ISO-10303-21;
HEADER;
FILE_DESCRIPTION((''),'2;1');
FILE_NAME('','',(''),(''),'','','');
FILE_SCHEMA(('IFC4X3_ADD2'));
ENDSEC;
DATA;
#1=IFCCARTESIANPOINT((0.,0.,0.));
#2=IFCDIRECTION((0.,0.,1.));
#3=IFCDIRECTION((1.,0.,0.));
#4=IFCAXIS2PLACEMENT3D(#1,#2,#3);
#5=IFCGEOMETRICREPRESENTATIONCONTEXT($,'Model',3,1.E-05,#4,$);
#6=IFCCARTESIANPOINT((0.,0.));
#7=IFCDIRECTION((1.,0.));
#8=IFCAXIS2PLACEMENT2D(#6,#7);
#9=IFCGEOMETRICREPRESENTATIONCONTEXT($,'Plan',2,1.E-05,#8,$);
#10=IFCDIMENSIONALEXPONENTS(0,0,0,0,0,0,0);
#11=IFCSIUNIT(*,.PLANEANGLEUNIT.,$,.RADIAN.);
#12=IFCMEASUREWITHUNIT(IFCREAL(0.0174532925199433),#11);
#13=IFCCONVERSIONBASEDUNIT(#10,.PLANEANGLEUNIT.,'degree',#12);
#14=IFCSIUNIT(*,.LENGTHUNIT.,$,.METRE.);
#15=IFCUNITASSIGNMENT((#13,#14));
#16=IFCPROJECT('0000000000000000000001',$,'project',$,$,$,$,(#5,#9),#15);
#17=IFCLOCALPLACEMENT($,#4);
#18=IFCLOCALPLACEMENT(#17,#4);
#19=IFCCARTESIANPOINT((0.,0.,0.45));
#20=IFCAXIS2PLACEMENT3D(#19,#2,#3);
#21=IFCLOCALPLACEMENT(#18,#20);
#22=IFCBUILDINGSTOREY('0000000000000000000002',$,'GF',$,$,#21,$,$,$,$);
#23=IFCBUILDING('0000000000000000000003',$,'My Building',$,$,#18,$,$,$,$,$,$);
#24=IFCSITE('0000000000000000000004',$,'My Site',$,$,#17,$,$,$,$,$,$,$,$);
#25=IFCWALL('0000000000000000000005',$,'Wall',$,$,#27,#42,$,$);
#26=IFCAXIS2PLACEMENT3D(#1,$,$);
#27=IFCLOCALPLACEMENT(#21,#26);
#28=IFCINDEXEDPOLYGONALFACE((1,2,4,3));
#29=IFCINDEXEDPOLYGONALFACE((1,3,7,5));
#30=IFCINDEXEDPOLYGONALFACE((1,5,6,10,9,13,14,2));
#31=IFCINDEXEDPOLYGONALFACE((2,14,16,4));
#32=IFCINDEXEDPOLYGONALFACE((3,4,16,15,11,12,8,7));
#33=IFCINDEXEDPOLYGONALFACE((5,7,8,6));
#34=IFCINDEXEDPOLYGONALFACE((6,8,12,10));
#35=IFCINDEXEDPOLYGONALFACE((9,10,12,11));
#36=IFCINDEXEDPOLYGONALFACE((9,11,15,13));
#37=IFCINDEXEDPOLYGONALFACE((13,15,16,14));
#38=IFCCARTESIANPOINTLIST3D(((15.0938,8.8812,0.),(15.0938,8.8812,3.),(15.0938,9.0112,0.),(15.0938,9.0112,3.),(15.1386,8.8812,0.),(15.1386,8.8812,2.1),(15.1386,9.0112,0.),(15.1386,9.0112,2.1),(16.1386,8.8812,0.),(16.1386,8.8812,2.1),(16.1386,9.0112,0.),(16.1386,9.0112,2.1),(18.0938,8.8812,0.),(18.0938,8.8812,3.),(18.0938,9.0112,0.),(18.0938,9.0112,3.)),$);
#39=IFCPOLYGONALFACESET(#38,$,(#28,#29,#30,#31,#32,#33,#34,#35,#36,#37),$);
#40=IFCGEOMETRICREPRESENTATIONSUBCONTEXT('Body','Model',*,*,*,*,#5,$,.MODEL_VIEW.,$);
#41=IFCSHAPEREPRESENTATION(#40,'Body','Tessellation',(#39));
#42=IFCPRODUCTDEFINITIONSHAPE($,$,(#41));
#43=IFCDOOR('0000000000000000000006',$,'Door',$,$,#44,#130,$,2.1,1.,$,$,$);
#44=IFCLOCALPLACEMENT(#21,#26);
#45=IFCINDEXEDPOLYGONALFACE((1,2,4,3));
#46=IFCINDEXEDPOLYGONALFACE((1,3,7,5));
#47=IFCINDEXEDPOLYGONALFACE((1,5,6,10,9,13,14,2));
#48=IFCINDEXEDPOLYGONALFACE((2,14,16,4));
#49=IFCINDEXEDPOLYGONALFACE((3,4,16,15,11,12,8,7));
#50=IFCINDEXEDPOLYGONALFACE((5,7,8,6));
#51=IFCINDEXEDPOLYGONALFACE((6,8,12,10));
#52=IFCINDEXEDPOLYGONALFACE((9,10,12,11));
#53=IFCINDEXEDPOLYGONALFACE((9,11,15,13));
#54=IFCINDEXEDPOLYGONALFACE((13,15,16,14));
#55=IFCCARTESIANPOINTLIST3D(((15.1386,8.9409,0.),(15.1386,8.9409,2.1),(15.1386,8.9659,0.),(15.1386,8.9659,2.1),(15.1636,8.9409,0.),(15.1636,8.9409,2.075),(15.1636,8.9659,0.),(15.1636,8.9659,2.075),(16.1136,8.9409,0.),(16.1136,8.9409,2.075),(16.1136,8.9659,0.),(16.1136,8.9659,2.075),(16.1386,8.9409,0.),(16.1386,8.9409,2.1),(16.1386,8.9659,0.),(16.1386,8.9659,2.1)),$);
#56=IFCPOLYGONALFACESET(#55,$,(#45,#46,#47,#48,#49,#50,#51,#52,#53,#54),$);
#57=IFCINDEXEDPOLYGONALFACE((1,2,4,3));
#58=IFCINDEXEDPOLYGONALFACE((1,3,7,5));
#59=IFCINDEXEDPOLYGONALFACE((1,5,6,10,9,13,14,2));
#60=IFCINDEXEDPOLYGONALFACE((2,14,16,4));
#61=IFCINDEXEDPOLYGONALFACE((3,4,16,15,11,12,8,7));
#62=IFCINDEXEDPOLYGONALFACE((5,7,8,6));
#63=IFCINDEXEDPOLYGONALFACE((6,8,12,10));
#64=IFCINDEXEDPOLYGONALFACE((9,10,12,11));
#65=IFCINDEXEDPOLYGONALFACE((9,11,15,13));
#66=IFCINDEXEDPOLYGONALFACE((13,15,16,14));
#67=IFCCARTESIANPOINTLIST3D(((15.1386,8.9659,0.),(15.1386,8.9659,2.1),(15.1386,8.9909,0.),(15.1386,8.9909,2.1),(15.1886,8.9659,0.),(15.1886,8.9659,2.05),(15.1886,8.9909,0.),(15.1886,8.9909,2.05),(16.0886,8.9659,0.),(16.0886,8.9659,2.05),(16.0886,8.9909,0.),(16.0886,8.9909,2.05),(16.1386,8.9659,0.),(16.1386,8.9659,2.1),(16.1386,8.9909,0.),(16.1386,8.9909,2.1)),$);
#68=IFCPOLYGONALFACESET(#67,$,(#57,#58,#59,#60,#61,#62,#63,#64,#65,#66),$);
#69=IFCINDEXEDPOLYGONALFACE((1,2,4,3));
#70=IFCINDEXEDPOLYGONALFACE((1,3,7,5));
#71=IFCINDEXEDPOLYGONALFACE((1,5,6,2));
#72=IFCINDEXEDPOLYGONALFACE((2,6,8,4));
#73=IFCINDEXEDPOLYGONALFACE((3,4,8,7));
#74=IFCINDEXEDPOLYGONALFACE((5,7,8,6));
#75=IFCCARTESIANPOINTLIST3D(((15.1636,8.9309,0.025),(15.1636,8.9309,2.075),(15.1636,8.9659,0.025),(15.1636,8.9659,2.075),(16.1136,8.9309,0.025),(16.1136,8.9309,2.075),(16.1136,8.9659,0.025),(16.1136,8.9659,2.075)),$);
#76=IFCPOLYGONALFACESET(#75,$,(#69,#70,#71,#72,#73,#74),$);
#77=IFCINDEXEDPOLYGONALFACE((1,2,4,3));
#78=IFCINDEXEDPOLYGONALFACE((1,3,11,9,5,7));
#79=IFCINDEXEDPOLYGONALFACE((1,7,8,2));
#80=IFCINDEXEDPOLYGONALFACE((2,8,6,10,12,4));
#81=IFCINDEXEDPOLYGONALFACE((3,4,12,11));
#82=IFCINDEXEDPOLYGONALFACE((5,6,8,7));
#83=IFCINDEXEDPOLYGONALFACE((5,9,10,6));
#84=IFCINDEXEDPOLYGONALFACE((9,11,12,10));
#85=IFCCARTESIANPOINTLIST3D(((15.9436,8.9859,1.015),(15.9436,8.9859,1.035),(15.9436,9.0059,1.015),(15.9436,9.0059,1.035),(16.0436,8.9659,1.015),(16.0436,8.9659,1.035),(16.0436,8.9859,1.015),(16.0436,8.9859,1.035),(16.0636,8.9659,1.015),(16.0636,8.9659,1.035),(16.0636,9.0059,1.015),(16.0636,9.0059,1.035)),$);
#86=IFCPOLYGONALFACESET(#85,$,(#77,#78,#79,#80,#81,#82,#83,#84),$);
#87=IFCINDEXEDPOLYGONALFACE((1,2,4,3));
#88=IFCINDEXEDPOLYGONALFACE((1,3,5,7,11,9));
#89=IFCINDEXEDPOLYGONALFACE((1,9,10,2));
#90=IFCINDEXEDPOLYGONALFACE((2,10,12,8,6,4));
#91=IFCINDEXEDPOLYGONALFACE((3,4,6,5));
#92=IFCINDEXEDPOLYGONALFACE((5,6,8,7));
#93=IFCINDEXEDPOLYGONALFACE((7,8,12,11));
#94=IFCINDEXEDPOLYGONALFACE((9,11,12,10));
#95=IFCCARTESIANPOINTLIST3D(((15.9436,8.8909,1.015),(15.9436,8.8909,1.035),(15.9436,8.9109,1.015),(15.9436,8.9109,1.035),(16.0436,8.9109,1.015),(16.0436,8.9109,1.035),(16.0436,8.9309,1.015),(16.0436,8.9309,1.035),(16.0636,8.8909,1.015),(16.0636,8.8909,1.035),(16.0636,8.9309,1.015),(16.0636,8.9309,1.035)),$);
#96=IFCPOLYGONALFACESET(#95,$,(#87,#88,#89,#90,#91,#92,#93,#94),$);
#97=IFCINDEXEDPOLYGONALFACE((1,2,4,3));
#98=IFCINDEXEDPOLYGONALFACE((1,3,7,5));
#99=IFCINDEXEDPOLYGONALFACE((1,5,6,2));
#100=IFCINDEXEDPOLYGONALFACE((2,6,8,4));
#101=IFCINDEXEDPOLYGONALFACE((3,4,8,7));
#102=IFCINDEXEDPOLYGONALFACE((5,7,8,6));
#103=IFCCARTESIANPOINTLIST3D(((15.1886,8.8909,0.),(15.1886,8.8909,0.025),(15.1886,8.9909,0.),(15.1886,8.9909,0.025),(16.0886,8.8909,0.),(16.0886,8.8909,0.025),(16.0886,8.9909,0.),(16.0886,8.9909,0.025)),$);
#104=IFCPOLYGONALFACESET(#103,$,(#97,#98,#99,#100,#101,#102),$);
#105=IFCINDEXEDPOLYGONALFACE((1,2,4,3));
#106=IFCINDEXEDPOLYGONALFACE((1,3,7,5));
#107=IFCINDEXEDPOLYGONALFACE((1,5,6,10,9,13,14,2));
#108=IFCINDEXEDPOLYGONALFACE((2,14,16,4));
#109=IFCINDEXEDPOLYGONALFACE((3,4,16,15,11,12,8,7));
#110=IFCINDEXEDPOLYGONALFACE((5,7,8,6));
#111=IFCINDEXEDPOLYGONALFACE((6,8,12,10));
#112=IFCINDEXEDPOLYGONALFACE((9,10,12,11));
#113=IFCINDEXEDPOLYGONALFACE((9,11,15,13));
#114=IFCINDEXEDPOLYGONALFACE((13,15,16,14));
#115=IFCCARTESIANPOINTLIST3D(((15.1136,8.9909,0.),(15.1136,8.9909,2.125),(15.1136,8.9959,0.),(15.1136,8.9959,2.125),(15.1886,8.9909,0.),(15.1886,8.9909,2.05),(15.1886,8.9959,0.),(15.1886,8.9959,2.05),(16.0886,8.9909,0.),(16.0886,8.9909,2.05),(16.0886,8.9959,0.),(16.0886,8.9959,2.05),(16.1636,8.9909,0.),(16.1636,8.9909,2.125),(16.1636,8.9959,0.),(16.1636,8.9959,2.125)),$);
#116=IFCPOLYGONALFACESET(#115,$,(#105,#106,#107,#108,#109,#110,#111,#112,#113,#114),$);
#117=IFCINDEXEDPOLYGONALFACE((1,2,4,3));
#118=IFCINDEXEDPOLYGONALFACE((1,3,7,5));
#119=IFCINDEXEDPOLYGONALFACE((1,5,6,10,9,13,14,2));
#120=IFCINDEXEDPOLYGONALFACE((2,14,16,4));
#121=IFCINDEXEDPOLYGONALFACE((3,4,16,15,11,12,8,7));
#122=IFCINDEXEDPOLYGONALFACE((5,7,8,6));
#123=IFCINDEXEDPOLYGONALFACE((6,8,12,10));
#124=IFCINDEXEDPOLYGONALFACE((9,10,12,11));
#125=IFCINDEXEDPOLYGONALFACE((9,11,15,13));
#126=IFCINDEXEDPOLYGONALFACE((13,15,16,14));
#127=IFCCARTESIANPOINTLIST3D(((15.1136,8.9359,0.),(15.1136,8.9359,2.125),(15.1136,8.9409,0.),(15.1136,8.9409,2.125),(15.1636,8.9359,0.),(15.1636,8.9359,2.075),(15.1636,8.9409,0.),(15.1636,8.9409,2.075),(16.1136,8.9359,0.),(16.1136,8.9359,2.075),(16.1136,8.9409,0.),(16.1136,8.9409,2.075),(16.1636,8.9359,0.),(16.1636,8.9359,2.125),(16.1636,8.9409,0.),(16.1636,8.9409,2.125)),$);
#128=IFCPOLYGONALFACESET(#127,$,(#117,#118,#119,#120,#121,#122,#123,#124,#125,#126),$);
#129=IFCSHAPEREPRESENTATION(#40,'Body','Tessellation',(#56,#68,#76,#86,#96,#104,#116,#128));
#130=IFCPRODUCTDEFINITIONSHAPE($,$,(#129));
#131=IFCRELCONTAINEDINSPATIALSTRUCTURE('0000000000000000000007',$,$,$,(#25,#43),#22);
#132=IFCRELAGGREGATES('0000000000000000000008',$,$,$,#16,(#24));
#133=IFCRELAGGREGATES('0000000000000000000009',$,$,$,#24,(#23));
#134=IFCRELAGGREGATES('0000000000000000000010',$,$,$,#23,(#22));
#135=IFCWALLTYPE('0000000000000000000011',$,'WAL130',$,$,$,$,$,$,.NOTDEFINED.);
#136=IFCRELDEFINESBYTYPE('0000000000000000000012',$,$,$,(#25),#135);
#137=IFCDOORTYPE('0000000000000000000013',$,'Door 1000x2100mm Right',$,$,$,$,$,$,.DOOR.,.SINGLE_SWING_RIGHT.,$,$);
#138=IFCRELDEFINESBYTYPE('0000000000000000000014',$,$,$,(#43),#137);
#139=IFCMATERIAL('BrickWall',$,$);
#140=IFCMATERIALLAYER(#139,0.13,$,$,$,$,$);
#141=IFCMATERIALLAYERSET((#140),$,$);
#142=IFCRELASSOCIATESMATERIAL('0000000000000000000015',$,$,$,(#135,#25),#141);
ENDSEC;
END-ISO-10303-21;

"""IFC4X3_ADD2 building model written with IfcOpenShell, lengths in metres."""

from ifc_helpers import new_model, entity, si_unit, converted_unit, frame, origin_with_axes, origin_2d_with_axis, place, context, subcontext, project, spatial, line, indexed_curve, outline, extrude, shape, source, transform, mapped, material, layer, layer_set, layer_usage, type_object, type_shapes, element, fill, save


model = new_model("IFC4X3_ADD2")

# Units and contexts
model_context = context("Model", 3, precision=1e-05, world=origin_with_axes())
plan_context = context("Plan", 2, precision=1e-05, world=origin_2d_with_axis())
body_context_1 = subcontext(model_context, "Body", "Model", "MODEL_VIEW")
body_context_2 = subcontext(plan_context, "Body", "Plan", "PLAN_VIEW")
ifc_project = project(units=[converted_unit("PLANEANGLEUNIT", "degree", entity("IfcReal", 0.0174532925199433), si_unit("PLANEANGLEUNIT", "RADIAN"), dimensions=[0, 0, 0, 0, 0, 0, 0]), si_unit("LENGTHUNIT", "METRE")], contexts=[model_context, plan_context])

# Site, building, storey
site_placement = place(None, origin_with_axes())
site = spatial("IfcSite", under=ifc_project, at=site_placement, Name="My Site")
building_placement = place(site_placement, origin_with_axes())
building = spatial("IfcBuilding", under=site, at=building_placement, Name="My Building")
storey_placement = place(building_placement, frame((0.0, 0.0, 0.45), z_axis=(0.0, 0.0, 1.0), x_axis=(1.0, 0.0, 0.0)))
storey = spatial("IfcBuildingStorey", under=building, at=storey_placement, Name="GF")

# Shared definitions
ifc_material_1 = material(Name="BrickWall")

# Wall, opening, door
ifc_layer_1 = layer(ifc_material_1, 0.13)
ifc_layer_set_1 = layer_set([ifc_layer_1])
ifc_layer_usage_1 = layer_usage(ifc_layer_set_1, "AXIS2", "POSITIVE", 0.0)
wall_type_1 = type_object("IfcWallType", Name="WAL130", PredefinedType="NOTDEFINED", material=ifc_layer_set_1)
wall_1_placement = place(storey_placement, frame((15.0938, 8.8812, 0.0), z_axis=(0.0, 0.0, 1.0), x_axis=(1.0, 0.0, 0.0)))
wall_1 = element("IfcWall", 1, at=wall_1_placement, inside=storey, type_object=wall_type_1, material=ifc_layer_usage_1, Name="Wall", context=body_context_1, shape_type="SweptSolid", body=[
    extrude(outline(indexed_curve([(0.0, 0.0), (0.0, 0.13), (3.0, 0.13), (3.0, 0.0), (0.0, 0.0)], self_intersect=False)), origin_with_axes(), (0.0, 0.0, 1.0), 3.0),
])
shared_shape_1 = source(origin_with_axes(), body_context_1, "Body", "SweptSolid", [
    extrude(outline(indexed_curve([(0.0, 0.0), (1.0, 0.0), (1.0, 2.1), (0.0, 2.1)], segments=[line(1, 2, 3, 4, 1)])), frame((0.0, -0.6, 0.0), z_axis=(0.0, -1.0, 0.0), x_axis=(1.0, 0.0, 0.0)), (0.0, 0.0, -1.0), 1.2),
])
opening_1_placement = place(wall_1_placement, frame((1.0447, 0.1097, 0.0), z_axis=(0.0, 0.0, 1.0), x_axis=(-1.0, 0.0, 0.0)))
opening_1 = element("IfcOpeningElement", 2, at=opening_1_placement, cuts=wall_1, PredefinedType="OPENING", context=body_context_1, shape_type="MappedRepresentation", body=[
    mapped(shared_shape_1, transform((0.0, 0.0, 0.0), x_axis=(1.0, 0.0, 0.0), y_axis=(0.0, 1.0, 0.0), z_axis=(0.0, 0.0, 1.0), scale=1.0)),
])
door_type_1 = type_object("IfcDoorType", Name="Door 1000x2100mm Right", OperationType="SINGLE_SWING_RIGHT", PredefinedType="DOOR")
shared_shape_2 = source(origin_with_axes(), body_context_1, "Body", "SweptSolid", [
    extrude(outline(indexed_curve([(0.0, 0.0), (0.0, 2.1), (1.0, 2.1), (1.0, 0.0), (0.975, 0.0), (0.975, 2.075), (0.025, 2.075), (0.025, 0.0)], segments=[line(1, 2, 3, 4, 5, 6, 7, 8, 1)])), frame((0.0, 0.025, 0.0), z_axis=(0.0, -1.0, 0.0), x_axis=(1.0, 0.0, 0.0)), (0.0, 0.0, -1.0), 0.025),
    extrude(outline(indexed_curve([(0.0, 0.0), (0.0, 2.1), (1.0, 2.1), (1.0, 0.0), (0.95, 0.0), (0.95, 2.05), (0.05, 2.05), (0.05, 0.0)], segments=[line(1, 2, 3, 4, 5, 6, 7, 8, 1)])), frame((0.0, 0.0, 0.0), z_axis=(0.0, -1.0, 0.0), x_axis=(1.0, 0.0, 0.0)), (0.0, 0.0, -1.0), 0.025),
    extrude(outline(indexed_curve([(0.0, 0.0), (0.95, 0.0), (0.95, 0.035), (0.0, 0.035)], segments=[line(1, 2, 3, 4, 1)])), frame((0.025, 0.025, 0.025), z_axis=(0.0, 0.0, 1.0), x_axis=(1.0, 0.0, 0.0)), (0.0, 0.0, 1.0), 2.05),
    extrude(outline(indexed_curve([(0.0, 0.0), (0.0, -0.04), (0.12, -0.04), (0.12, -0.02), (0.02, -0.02), (0.02, 0.0)], segments=[line(1, 2, 3, 4, 5, 6, 1)])), frame((0.075, 0.025, 1.015), z_axis=(0.0, 0.0, 1.0), x_axis=(1.0, 0.0, 0.0)), (0.0, 0.0, 1.0), 0.02),
    extrude(outline(indexed_curve([(0.0, 0.0), (0.0, 0.04), (0.12, 0.04), (0.12, 0.02), (0.02, 0.02), (0.02, 0.0)], segments=[line(1, 2, 3, 4, 5, 6, 1)])), frame((0.075, 0.06, 1.015), z_axis=(0.0, 0.0, 1.0), x_axis=(1.0, 0.0, 0.0)), (0.0, 0.0, 1.0), 0.02),
    extrude(outline(indexed_curve([(0.0, 0.0), (0.9, 0.0), (0.9, 0.1), (0.0, 0.1)], segments=[line(1, 2, 3, 4, 1)])), frame((0.05, 0.0, 0.0), z_axis=(0.0, 0.0, 1.0), x_axis=(1.0, 0.0, 0.0)), (0.0, 0.0, 1.0), 0.025),
    extrude(outline(indexed_curve([(0.0, 0.0), (0.0, 2.125), (1.05, 2.125), (1.05, 0.0), (0.975, 0.0), (0.975, 2.05), (0.075, 2.05), (0.075, 0.0)], segments=[line(1, 2, 3, 4, 5, 6, 7, 8, 1)])), frame((-0.025, -0.005, 0.0), z_axis=(0.0, -1.0, 0.0), x_axis=(1.0, 0.0, 0.0)), (0.0, 0.0, -1.0), 0.005),
    extrude(outline(indexed_curve([(0.0, 0.0), (0.0, 2.125), (1.05, 2.125), (1.05, 0.0), (1.0, 0.0), (1.0, 2.075), (0.05, 2.075), (0.05, 0.0)], segments=[line(1, 2, 3, 4, 5, 6, 7, 8, 1)])), frame((-0.025, 0.05, 0.0), z_axis=(0.0, -1.0, 0.0), x_axis=(1.0, 0.0, 0.0)), (0.0, 0.0, -1.0), 0.005),
])
shared_shape_3 = source(origin_with_axes(), body_context_2, "Body", "Curve2D", [
    entity("IfcIndexedPolyCurve", entity("IfcCartesianPointList2D", [[0.0, 0.0], [0.0, 0.05], [0.025, 0.05], [0.025, 0.025], [0.05, 0.025], [0.05, 0.0]]), [entity("IfcLineIndex", [1, 2, 3, 4, 5, 6, 1])]),
    entity("IfcIndexedPolyCurve", entity("IfcCartesianPointList2D", [[1.0, 0.0], [1.0, 0.05], [0.975, 0.05], [0.975, 0.025], [0.95, 0.025], [0.95, 0.0]]), [entity("IfcLineIndex", [1, 2, 3, 4, 5, 6, 1])]),
    entity("IfcTrimmedCurve", entity("IfcEllipse", entity("IfcAxis2Placement2D", entity("IfcCartesianPoint", [0.94, 0.05]), entity("IfcDirection", [1.0, 0.0])), 0.915, 0.95), [entity("IfcCartesianPoint", [0.94, 1.0])], [entity("IfcCartesianPoint", [0.025, 0.05])], True, "CARTESIAN"),
    entity("IfcIndexedPolyCurve", entity("IfcCartesianPointList2D", [[0.975, 0.05], [0.94, 0.05], [0.94, 1.0], [0.975, 1.0]]), [entity("IfcLineIndex", [1, 2, 3, 4, 1])]),
])
type_shapes(door_type_1, [shared_shape_2, shared_shape_3])
door_1_placement = place(opening_1_placement, origin_with_axes())
door_1 = element("IfcDoor", 3, at=door_1_placement, inside=storey, type_object=door_type_1, Name="Door", OverallHeight=2.1, OverallWidth=1.0, shapes=[
    shape(body_context_1, "Body", "MappedRepresentation", [mapped(shared_shape_2, transform((0.0, 0.0, 0.0), x_axis=(1.0, 0.0, 0.0), y_axis=(0.0, 1.0, 0.0), z_axis=(0.0, 0.0, 1.0), scale=1.0))]),
    shape(body_context_2, "Body", "MappedRepresentation", [mapped(shared_shape_3, transform((0.0, 0.0, 0.0), x_axis=(1.0, 0.0, 0.0), y_axis=(0.0, 1.0, 0.0), z_axis=(0.0, 0.0, 1.0), scale=1.0))]),
])
fill(opening_1, door_1)

save(model, "model.ifc")
